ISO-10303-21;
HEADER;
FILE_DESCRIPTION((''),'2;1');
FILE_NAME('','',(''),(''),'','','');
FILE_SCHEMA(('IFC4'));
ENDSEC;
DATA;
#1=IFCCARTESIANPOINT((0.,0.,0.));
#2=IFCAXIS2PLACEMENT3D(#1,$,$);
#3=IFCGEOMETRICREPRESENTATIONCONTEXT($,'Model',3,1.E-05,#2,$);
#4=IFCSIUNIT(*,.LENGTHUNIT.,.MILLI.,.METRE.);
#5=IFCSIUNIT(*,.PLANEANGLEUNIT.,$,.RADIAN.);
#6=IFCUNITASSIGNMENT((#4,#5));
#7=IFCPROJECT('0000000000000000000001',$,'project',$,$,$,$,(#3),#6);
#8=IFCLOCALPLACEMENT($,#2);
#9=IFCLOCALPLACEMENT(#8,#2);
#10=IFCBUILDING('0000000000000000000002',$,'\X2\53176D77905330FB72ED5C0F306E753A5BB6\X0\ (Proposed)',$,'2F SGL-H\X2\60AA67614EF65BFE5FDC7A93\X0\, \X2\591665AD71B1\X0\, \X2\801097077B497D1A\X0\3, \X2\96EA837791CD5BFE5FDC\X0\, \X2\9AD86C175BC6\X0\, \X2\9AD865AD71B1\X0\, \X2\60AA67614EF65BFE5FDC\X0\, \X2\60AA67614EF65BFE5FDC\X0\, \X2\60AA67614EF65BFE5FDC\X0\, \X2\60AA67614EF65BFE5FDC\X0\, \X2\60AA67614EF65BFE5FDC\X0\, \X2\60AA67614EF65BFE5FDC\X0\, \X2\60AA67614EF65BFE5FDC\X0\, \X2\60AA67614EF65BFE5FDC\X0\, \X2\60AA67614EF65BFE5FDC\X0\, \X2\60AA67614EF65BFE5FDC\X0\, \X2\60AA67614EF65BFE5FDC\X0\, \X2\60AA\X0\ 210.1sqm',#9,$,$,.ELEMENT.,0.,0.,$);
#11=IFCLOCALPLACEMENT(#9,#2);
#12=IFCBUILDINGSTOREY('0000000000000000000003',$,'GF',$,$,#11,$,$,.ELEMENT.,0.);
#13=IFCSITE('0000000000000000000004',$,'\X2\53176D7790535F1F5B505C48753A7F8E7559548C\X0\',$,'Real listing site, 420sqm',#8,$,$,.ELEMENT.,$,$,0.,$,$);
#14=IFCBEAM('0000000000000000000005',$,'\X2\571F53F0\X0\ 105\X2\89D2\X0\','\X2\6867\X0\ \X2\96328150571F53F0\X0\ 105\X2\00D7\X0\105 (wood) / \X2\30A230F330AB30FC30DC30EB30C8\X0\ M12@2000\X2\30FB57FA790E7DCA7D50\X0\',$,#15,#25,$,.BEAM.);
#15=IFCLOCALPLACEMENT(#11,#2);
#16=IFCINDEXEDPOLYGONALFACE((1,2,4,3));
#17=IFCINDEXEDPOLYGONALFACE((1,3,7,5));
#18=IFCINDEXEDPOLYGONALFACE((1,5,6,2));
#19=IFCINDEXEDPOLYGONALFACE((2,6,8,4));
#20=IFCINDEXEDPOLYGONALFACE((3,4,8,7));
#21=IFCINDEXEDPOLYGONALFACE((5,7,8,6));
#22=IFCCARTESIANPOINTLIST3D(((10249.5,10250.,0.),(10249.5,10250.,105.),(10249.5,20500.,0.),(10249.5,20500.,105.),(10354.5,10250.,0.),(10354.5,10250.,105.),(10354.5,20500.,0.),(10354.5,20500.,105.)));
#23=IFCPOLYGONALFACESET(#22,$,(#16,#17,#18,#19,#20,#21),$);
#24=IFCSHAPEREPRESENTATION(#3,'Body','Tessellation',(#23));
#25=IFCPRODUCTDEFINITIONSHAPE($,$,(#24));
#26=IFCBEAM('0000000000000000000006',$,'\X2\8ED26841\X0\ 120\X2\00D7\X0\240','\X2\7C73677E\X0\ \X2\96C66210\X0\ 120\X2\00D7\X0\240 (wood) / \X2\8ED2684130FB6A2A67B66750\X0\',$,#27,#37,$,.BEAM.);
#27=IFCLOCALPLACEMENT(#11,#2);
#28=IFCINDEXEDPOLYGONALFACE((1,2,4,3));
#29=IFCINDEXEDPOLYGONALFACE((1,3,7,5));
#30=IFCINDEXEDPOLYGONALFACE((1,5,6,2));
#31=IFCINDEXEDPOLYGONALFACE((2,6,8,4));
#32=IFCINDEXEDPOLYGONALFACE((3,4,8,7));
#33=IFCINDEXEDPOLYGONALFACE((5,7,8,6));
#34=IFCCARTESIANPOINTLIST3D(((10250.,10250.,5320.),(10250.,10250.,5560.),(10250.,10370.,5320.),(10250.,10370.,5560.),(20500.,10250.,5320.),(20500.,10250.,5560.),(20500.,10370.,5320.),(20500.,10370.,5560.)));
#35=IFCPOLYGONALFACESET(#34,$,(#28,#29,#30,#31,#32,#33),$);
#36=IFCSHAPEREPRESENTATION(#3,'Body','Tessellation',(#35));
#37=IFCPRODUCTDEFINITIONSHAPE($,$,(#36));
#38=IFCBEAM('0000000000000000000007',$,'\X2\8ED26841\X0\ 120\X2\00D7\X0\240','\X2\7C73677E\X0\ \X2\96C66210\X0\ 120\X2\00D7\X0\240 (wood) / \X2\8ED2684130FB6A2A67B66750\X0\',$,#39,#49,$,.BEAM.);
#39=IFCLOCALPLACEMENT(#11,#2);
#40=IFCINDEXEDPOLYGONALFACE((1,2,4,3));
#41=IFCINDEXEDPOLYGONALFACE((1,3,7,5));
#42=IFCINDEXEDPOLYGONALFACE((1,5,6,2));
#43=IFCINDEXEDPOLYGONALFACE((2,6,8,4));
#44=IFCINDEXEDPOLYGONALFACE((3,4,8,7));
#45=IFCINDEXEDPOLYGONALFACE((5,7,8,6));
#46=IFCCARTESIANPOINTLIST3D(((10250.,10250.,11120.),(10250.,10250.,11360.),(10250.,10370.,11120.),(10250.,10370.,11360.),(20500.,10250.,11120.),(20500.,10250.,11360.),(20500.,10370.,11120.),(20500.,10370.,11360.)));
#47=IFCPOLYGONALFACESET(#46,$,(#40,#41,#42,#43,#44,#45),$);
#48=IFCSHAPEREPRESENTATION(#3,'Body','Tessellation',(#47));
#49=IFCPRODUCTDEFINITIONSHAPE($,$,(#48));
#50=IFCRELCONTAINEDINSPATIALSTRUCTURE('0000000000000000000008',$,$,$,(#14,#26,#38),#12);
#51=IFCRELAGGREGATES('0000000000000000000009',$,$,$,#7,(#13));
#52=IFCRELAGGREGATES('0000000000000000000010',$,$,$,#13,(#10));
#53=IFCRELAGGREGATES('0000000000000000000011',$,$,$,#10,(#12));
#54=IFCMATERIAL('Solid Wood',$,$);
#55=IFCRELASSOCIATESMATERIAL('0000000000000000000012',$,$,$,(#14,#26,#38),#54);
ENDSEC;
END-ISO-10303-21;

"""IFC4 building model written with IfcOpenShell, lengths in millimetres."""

from ifc_helpers import new_model, si_unit, frame, frame_2d, origin, place, context, project, spatial, rectangle, extrude, material, element, save


model = new_model("IFC4")

# Units and contexts
model_context = context("Model", 3, precision=1e-05, world=origin())
ifc_project = project(units=[si_unit("LENGTHUNIT", "METRE", prefix="MILLI"), si_unit("PLANEANGLEUNIT", "RADIAN")], contexts=[model_context])

# Site, building, storey
site_placement = place(None, origin())
site = spatial("IfcSite", under=ifc_project, at=site_placement, Name="北海道弟子屈町美留和", ObjectType="Real listing site, 420sqm", CompositionType="ELEMENT", RefElevation=0.0)
building_placement = place(site_placement, origin())
building = spatial("IfcBuilding", under=site, at=building_placement, Name="北海道・狭小の町家 (Proposed)", ObjectType="2F SGL-H悪条件対応窓, 外断熱, 耐震等級3, 雪荷重対応, 高気密, 高断熱, 悪条件対応, 悪条件対応, 悪条件対応, 悪条件対応, 悪条件対応, 悪条件対応, 悪条件対応, 悪条件対応, 悪条件対応, 悪条件対応, 悪条件対応, 悪 210.1sqm", CompositionType="ELEMENT", ElevationOfRefHeight=0.0, ElevationOfTerrain=0.0)
storey_placement = place(building_placement, origin())
storey = spatial("IfcBuildingStorey", under=building, at=storey_placement, Name="GF", CompositionType="ELEMENT", Elevation=0.0)

# Shared definitions
ifc_material_1 = material(Name="Solid Wood")

# Beams
beam_1_placement = place(storey_placement, frame((5125.0, 5125.0, 0.0)))
element("IfcBeam", 1, at=beam_1_placement, inside=storey, material=ifc_material_1, Name="土台 105角", Description="桧 防腐土台 105×105 (wood) / アンカーボルト M12@2000・基礎緊結", PredefinedType="BEAM", context=model_context, shape_type="SweptSolid", body=[
    extrude(rectangle(XDim=105.0, YDim=10250.0, at=frame_2d((52.0, 5125.0))), frame((5125.0, 5125.0, 0.0)), (0.0, 0.0, 1.0), 105.0),
])
beam_2_placement = place(storey_placement, frame((5125.0, 5125.0, 2660.0)))
element("IfcBeam", 2, at=beam_2_placement, inside=storey, material=ifc_material_1, Name="軒桁 120×240", Description="米松 集成 120×240 (wood) / 軒桁・横架材", PredefinedType="BEAM", context=model_context, shape_type="SweptSolid", body=[
    extrude(rectangle(XDim=10250.0, YDim=120.0, at=frame_2d((5125.0, 60.0))), frame((5125.0, 5125.0, 2660.0)), (0.0, 0.0, 1.0), 240.0),
])
beam_3_placement = place(storey_placement, frame((5125.0, 5125.0, 5560.0)))
element("IfcBeam", 3, at=beam_3_placement, inside=storey, material=ifc_material_1, Name="軒桁 120×240", Description="米松 集成 120×240 (wood) / 軒桁・横架材", PredefinedType="BEAM", context=model_context, shape_type="SweptSolid", body=[
    extrude(rectangle(XDim=10250.0, YDim=120.0, at=frame_2d((5125.0, 60.0))), frame((5125.0, 5125.0, 5560.0)), (0.0, 0.0, 1.0), 240.0),
])

save(model, "model.ifc")
